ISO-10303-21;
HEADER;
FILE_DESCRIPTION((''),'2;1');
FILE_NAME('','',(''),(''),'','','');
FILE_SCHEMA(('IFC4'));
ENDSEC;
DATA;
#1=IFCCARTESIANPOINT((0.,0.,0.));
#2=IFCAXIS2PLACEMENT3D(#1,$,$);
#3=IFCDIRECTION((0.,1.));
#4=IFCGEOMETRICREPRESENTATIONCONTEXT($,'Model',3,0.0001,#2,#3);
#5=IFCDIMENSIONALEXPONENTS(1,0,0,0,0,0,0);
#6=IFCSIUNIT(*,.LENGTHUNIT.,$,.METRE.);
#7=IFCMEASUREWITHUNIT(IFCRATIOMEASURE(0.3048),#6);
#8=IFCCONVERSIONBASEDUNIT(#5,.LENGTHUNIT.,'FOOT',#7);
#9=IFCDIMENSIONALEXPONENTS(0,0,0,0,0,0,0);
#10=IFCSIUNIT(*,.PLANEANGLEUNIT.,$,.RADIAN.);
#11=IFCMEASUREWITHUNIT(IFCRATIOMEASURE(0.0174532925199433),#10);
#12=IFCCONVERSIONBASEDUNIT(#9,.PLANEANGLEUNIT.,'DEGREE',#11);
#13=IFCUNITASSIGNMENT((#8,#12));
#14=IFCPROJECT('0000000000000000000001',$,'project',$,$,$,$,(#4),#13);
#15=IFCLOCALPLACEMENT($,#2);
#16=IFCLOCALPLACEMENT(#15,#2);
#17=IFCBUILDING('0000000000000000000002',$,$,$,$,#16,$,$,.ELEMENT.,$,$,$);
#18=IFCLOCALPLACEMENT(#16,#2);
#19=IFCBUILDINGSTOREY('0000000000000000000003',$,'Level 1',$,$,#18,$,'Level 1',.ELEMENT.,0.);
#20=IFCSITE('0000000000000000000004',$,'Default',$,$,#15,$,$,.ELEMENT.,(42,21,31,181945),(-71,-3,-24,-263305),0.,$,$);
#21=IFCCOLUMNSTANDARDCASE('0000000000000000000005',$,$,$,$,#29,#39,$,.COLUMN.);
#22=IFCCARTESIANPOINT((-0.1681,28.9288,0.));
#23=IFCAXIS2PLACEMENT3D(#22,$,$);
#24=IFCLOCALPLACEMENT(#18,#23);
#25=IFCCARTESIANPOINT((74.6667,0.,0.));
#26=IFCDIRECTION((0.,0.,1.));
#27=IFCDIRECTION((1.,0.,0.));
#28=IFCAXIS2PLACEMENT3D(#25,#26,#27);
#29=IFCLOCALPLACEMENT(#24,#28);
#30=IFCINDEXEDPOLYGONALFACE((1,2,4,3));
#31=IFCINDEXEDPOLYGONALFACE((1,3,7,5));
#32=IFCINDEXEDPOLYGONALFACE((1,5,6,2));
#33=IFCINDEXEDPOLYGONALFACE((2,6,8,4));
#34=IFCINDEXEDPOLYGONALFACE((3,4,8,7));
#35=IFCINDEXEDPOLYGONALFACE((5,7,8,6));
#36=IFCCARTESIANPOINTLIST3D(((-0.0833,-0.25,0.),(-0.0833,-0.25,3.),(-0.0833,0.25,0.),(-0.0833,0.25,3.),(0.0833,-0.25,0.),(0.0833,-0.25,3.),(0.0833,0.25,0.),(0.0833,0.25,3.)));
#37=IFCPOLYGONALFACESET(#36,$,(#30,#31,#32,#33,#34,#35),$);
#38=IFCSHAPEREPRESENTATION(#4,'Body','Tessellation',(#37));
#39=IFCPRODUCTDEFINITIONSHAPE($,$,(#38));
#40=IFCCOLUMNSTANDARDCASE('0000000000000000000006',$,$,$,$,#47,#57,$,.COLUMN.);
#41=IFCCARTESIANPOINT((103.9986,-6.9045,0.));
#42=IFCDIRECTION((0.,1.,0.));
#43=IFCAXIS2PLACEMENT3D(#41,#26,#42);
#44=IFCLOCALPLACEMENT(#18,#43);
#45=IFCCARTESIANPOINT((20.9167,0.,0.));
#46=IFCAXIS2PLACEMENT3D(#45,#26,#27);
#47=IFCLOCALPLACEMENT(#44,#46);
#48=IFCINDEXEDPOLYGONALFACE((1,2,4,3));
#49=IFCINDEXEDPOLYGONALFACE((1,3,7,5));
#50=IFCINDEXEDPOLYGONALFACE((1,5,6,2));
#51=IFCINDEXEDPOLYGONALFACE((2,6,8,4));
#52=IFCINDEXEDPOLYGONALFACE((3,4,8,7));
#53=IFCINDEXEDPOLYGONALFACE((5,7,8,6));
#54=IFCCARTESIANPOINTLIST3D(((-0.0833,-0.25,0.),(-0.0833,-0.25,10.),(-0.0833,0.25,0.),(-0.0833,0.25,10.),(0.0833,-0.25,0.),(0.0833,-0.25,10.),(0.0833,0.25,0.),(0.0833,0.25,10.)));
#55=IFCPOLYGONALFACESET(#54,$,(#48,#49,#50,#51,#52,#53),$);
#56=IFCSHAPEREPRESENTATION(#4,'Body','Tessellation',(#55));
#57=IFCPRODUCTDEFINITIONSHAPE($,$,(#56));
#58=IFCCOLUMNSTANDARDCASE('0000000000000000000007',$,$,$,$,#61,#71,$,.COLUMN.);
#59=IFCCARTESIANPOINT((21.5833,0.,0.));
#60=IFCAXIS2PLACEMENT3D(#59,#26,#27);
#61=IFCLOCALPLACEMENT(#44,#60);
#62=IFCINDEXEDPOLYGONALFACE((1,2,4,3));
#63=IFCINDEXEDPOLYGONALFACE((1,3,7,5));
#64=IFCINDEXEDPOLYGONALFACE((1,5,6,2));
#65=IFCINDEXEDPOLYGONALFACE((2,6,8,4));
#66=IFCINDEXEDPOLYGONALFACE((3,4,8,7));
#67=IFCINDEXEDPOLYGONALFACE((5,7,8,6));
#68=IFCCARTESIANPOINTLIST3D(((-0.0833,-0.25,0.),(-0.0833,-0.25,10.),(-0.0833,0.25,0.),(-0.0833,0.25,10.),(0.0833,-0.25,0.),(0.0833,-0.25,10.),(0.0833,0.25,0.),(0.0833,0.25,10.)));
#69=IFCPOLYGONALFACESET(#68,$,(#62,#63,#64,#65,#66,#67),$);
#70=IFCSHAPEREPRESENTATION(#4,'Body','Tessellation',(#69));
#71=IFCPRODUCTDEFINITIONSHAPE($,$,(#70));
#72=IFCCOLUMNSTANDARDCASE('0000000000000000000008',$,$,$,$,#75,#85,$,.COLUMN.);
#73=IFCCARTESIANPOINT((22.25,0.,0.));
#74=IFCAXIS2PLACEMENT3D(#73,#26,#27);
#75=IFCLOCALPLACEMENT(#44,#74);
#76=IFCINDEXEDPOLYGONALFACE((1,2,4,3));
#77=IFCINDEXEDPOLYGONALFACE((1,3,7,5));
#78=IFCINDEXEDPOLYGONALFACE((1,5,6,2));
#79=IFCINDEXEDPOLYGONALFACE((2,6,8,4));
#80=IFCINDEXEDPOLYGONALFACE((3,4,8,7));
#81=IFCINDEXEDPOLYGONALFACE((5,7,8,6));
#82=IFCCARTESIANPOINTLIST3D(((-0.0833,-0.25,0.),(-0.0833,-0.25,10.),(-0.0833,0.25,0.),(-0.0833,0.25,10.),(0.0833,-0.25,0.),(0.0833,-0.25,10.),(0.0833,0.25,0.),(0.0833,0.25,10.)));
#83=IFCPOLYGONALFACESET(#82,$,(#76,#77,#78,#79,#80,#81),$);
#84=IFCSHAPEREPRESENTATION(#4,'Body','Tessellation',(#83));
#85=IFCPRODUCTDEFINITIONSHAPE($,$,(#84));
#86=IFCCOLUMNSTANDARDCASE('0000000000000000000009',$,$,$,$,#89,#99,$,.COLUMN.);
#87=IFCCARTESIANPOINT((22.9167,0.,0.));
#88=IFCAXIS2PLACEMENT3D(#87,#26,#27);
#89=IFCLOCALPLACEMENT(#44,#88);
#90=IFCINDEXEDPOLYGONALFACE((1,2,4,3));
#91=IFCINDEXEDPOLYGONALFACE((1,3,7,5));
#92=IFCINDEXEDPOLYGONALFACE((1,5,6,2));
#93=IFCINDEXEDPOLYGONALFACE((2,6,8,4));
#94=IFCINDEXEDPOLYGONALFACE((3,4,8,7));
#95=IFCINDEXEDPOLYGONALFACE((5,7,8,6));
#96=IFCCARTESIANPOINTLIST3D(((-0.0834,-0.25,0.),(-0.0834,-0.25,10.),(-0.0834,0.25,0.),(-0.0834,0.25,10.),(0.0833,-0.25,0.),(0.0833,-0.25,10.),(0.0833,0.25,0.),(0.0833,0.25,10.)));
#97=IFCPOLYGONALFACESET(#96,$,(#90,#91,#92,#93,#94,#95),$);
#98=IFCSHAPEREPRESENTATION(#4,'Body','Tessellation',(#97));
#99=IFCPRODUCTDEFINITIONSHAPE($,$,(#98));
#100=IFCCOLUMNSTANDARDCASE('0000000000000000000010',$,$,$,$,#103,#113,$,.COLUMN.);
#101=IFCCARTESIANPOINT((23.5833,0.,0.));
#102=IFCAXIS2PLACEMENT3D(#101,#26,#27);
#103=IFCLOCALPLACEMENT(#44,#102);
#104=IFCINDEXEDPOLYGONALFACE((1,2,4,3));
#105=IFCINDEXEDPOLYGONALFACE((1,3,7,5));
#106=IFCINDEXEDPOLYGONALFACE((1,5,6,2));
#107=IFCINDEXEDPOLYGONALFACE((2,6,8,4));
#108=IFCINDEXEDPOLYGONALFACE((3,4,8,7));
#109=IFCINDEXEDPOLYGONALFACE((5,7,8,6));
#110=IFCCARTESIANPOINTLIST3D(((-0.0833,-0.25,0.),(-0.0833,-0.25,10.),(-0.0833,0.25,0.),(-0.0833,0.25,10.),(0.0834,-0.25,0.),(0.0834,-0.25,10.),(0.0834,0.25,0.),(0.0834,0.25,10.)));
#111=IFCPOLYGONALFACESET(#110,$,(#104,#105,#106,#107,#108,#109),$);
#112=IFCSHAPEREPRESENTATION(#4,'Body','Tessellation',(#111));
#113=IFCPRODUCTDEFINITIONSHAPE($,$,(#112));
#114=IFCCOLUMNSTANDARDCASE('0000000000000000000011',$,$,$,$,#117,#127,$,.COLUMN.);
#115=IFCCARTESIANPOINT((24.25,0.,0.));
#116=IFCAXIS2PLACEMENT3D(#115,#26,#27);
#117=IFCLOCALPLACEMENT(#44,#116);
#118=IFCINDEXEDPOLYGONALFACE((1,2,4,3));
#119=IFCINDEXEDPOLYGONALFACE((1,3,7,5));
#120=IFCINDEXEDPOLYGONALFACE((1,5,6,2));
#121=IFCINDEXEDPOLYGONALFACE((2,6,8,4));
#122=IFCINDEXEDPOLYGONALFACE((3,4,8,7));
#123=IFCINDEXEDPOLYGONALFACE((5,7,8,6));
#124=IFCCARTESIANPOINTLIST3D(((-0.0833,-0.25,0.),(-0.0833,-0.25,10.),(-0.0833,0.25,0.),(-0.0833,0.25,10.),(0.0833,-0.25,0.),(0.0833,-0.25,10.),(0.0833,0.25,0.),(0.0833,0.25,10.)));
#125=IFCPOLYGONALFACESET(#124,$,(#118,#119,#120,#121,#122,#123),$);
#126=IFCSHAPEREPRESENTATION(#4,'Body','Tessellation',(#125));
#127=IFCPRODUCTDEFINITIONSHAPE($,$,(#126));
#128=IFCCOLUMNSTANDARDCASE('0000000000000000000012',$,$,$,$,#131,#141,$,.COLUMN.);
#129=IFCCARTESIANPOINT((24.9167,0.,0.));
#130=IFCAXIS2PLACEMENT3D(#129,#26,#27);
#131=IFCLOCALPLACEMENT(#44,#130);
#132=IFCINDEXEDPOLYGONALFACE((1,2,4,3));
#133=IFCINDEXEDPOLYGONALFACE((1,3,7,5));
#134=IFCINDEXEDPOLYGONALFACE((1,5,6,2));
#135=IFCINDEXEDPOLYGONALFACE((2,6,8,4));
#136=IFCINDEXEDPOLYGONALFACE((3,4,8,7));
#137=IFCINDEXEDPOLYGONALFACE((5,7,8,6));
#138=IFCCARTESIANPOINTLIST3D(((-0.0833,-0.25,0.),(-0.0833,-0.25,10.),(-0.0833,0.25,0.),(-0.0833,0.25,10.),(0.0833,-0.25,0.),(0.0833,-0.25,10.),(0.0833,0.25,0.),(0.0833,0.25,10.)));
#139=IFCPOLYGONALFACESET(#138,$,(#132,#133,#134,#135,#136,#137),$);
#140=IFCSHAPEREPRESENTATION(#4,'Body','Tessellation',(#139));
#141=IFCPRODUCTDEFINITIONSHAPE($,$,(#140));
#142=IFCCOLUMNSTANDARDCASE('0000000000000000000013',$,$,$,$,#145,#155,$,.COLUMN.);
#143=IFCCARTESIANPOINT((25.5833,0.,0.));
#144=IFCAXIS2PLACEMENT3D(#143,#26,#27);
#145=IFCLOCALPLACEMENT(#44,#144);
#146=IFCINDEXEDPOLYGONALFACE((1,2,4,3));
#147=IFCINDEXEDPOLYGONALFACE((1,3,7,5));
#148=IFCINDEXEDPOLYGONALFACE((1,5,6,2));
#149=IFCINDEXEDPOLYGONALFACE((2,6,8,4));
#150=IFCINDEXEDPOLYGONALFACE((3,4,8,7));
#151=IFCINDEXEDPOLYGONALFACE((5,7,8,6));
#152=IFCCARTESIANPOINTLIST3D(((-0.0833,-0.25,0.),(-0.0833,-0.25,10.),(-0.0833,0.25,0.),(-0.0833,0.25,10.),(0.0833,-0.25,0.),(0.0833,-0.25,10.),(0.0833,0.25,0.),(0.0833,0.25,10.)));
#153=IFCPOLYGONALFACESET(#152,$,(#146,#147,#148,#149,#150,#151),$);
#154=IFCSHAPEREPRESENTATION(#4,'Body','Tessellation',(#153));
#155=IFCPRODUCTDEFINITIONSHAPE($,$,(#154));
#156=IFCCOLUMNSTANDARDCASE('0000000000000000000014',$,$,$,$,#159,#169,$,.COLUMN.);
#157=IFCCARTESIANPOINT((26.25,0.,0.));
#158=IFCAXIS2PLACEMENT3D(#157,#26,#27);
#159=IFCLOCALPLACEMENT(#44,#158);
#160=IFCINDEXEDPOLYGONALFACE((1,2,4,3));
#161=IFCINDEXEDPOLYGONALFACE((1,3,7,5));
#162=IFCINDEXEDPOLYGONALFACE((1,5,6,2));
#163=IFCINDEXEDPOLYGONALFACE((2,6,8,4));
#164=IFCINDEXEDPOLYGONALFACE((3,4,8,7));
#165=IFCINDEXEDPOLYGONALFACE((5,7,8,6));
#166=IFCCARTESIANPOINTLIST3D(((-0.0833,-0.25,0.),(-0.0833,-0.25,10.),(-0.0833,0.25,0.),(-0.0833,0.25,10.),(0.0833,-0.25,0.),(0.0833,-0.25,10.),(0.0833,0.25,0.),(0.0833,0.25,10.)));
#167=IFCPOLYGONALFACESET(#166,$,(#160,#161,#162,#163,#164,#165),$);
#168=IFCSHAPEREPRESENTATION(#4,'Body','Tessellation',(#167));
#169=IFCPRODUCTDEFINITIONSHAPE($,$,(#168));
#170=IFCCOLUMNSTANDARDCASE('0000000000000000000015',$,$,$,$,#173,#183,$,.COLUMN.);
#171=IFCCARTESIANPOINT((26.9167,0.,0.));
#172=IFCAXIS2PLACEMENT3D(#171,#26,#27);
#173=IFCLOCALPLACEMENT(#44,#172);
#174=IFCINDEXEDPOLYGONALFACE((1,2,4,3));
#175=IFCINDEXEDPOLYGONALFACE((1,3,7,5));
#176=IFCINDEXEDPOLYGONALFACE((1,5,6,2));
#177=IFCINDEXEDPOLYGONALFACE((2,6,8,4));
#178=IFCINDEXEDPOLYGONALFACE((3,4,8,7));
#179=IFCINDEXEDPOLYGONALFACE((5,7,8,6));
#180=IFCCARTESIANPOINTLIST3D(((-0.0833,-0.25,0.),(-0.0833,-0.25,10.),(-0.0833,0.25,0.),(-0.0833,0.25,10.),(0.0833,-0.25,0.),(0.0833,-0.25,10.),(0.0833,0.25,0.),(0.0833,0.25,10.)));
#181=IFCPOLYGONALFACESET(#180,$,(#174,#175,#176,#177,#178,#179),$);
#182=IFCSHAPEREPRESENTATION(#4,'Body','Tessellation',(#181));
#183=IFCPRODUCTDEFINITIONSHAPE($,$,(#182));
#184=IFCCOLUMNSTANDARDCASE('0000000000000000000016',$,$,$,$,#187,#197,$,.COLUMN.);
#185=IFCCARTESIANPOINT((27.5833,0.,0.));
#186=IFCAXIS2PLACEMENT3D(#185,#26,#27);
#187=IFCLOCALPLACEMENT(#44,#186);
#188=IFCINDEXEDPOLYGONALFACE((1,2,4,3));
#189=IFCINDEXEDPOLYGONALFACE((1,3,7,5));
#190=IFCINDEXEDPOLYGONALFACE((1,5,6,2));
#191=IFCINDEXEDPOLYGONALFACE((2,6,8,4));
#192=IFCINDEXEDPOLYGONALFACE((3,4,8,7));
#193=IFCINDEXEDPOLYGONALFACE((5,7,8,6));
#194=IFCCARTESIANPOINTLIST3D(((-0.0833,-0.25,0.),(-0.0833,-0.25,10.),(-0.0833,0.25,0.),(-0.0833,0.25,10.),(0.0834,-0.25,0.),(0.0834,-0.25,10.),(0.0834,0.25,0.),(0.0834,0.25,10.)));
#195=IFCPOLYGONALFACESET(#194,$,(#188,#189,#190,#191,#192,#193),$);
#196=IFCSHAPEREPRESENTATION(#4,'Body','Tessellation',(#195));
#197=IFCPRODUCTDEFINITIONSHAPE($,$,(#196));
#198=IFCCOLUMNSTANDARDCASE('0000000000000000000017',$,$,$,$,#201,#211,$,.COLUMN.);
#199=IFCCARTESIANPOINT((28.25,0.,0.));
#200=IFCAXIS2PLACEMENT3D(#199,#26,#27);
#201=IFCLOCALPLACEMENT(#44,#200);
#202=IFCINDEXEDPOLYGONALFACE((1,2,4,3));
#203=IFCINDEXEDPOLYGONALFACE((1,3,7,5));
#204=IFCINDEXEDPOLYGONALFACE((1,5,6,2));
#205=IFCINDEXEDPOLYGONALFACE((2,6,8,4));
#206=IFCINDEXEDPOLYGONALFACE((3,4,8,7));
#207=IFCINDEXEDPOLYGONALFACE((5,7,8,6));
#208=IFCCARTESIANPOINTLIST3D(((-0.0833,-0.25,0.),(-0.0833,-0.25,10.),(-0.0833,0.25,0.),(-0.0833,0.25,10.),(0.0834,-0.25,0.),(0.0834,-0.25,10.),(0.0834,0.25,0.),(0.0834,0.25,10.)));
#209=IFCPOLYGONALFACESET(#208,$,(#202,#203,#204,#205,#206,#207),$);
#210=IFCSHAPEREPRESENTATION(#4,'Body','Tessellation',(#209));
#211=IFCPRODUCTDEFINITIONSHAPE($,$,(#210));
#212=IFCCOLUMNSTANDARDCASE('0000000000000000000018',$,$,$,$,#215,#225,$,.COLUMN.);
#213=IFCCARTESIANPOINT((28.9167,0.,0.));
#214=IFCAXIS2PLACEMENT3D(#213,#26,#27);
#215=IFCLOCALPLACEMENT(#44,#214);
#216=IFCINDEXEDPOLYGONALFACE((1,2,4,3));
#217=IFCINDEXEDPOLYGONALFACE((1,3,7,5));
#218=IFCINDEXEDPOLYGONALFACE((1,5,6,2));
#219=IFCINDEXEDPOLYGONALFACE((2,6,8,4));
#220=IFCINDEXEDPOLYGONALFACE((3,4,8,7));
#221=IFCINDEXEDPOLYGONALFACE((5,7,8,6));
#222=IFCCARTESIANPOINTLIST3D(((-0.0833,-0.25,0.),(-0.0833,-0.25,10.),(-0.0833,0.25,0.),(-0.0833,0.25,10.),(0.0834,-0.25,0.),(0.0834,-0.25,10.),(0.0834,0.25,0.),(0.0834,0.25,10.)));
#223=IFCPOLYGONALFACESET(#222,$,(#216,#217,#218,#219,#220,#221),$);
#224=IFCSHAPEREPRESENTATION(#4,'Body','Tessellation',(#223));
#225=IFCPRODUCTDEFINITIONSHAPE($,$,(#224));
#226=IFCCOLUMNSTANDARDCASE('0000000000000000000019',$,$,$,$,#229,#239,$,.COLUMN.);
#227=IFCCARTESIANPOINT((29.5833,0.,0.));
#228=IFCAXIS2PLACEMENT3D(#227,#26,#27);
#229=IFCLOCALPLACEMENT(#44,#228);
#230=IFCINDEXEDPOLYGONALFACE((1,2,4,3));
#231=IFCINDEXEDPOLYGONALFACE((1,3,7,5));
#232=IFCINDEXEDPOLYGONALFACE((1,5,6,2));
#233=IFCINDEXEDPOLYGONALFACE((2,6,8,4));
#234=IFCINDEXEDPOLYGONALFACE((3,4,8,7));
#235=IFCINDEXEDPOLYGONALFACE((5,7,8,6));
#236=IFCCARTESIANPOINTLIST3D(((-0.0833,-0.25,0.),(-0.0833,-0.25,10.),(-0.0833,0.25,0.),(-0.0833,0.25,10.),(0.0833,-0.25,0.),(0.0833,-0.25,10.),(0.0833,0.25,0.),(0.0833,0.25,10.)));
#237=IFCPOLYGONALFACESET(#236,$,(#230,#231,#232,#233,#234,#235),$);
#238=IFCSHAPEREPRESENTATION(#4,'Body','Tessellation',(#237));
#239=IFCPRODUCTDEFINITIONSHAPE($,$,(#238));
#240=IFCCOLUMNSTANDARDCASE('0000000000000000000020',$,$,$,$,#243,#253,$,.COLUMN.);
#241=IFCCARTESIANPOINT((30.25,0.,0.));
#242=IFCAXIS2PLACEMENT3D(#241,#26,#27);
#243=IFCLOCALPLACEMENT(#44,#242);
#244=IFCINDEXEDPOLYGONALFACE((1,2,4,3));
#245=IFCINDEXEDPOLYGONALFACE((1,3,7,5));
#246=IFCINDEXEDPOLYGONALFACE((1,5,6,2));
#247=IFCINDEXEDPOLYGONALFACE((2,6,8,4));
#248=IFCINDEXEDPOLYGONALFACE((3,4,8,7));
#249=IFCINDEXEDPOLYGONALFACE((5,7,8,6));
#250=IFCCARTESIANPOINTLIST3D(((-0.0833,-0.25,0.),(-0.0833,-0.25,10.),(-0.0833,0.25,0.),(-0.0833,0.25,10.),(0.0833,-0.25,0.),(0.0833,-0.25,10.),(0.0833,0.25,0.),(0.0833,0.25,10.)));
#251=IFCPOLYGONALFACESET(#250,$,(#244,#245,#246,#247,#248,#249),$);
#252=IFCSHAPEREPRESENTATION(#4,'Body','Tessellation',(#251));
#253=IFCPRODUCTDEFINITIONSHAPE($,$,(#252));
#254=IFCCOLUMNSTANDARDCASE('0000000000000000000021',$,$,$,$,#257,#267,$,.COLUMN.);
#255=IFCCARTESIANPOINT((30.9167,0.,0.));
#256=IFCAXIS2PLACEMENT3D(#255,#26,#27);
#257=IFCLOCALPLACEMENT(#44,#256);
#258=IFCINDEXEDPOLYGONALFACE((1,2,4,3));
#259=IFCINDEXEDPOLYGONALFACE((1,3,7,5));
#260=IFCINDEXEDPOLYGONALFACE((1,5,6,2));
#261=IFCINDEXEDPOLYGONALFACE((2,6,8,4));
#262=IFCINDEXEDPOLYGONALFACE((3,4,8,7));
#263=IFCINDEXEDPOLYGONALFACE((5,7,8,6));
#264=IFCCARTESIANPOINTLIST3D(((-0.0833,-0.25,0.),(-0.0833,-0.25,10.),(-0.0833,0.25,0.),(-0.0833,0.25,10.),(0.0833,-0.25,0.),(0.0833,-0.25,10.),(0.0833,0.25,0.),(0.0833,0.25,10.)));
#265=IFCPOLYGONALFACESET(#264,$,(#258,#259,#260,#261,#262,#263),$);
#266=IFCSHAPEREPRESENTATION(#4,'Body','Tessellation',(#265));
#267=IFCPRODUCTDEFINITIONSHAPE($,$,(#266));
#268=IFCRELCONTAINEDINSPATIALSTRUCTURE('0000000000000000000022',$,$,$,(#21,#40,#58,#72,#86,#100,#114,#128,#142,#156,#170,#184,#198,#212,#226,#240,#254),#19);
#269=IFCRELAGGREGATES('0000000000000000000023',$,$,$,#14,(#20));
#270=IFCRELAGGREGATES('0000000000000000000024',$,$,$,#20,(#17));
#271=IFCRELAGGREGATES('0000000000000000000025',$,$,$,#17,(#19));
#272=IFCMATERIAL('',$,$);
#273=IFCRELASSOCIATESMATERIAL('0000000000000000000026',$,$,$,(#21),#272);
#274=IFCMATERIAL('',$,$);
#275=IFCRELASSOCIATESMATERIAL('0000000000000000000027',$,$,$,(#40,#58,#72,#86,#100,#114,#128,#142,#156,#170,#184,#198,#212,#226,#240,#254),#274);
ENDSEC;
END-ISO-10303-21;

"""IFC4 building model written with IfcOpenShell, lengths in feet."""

from ifc_helpers import new_model, entity, si_unit, converted_unit, direction, frame, origin, place, context, project, spatial, rectangle, extrude, material, element, save


model = new_model("IFC4")

# Units and contexts
model_context = context("Model", 3, precision=0.0001, world=origin(), true_north=direction((0.0, 1.0)))
ifc_project = project(units=[converted_unit("LENGTHUNIT", "FOOT", entity("IfcRatioMeasure", 0.3048), si_unit("LENGTHUNIT", "METRE"), dimensions=[1, 0, 0, 0, 0, 0, 0]), converted_unit("PLANEANGLEUNIT", "DEGREE", entity("IfcRatioMeasure", 0.0174532925199433), si_unit("PLANEANGLEUNIT", "RADIAN"), dimensions=[0, 0, 0, 0, 0, 0, 0])], contexts=[model_context])

# Site, building, storey
site_placement = place(None, origin())
site = spatial("IfcSite", under=ifc_project, at=site_placement, Name="Default", CompositionType="ELEMENT", RefLatitude=(42, 21, 31, 181945), RefLongitude=(-71, -3, -24, -263305), RefElevation=0.0)
building_placement = place(site_placement, origin())
building = spatial("IfcBuilding", under=site, at=building_placement, CompositionType="ELEMENT")
storey_placement = place(building_placement, origin())
storey = spatial("IfcBuildingStorey", under=building, at=storey_placement, Name="Level 1", LongName="Level 1", CompositionType="ELEMENT", Elevation=0.0)

# Columns
ifc_material_1 = material(Name="")
placement_1 = place(storey_placement, frame((-0.1681, 28.9288, 0.0)))
for number, where, z_axis, x_axis in (
    (1, (74.6667, 0.0, 0.0), (0.0, 0.0, 1.0), (1.0, 0.0, 0.0)),
):
    element("IfcColumnStandardCase", number, at=place(placement_1, frame(where, z_axis=z_axis, x_axis=x_axis)), inside=storey, material=ifc_material_1, PredefinedType="COLUMN", context=model_context, shape_type="SweptSolid", body=[
        extrude(rectangle(XDim=0.1667, YDim=0.5), origin(), (0.0, 0.0, 1.0), 3.0),
    ])
ifc_material_2 = material(Name="")
placement_2 = place(storey_placement, frame((103.9986, -6.9045, 0.0), z_axis=(0.0, 0.0, 1.0), x_axis=(0.0, 1.0, 0.0)))
for number, where, z_axis, x_axis in (
    (2, (20.9167, 0.0, 0.0), (0.0, 0.0, 1.0), (1.0, 0.0, 0.0)),
    (3, (21.5833, 0.0, 0.0), (0.0, 0.0, 1.0), (1.0, 0.0, 0.0)),
    (4, (22.25, 0.0, 0.0), (0.0, 0.0, 1.0), (1.0, 0.0, 0.0)),
    (5, (22.9167, 0.0, 0.0), (0.0, 0.0, 1.0), (1.0, 0.0, 0.0)),
    (6, (23.5833, 0.0, 0.0), (0.0, 0.0, 1.0), (1.0, 0.0, 0.0)),
    (7, (24.25, 0.0, 0.0), (0.0, 0.0, 1.0), (1.0, 0.0, 0.0)),
    (8, (24.9167, 0.0, 0.0), (0.0, 0.0, 1.0), (1.0, 0.0, 0.0)),
    (9, (25.5833, 0.0, 0.0), (0.0, 0.0, 1.0), (1.0, 0.0, 0.0)),
    (10, (26.25, 0.0, 0.0), (0.0, 0.0, 1.0), (1.0, 0.0, 0.0)),
    (11, (26.9167, 0.0, 0.0), (0.0, 0.0, 1.0), (1.0, 0.0, 0.0)),
    (12, (27.5833, 0.0, 0.0), (0.0, 0.0, 1.0), (1.0, 0.0, 0.0)),
    (13, (28.25, 0.0, 0.0), (0.0, 0.0, 1.0), (1.0, 0.0, 0.0)),
    (14, (28.9167, 0.0, 0.0), (0.0, 0.0, 1.0), (1.0, 0.0, 0.0)),
    (15, (29.5833, 0.0, 0.0), (0.0, 0.0, 1.0), (1.0, 0.0, 0.0)),
    (16, (30.25, 0.0, 0.0), (0.0, 0.0, 1.0), (1.0, 0.0, 0.0)),
    (17, (30.9167, 0.0, 0.0), (0.0, 0.0, 1.0), (1.0, 0.0, 0.0)),
):
    element("IfcColumnStandardCase", number, at=place(placement_2, frame(where, z_axis=z_axis, x_axis=x_axis)), inside=storey, material=ifc_material_2, PredefinedType="COLUMN", context=model_context, shape_type="SweptSolid", body=[
        extrude(rectangle(XDim=0.1667, YDim=0.5), origin(), (0.0, 0.0, 1.0), 10.0),
    ])

save(model, "model.ifc")
